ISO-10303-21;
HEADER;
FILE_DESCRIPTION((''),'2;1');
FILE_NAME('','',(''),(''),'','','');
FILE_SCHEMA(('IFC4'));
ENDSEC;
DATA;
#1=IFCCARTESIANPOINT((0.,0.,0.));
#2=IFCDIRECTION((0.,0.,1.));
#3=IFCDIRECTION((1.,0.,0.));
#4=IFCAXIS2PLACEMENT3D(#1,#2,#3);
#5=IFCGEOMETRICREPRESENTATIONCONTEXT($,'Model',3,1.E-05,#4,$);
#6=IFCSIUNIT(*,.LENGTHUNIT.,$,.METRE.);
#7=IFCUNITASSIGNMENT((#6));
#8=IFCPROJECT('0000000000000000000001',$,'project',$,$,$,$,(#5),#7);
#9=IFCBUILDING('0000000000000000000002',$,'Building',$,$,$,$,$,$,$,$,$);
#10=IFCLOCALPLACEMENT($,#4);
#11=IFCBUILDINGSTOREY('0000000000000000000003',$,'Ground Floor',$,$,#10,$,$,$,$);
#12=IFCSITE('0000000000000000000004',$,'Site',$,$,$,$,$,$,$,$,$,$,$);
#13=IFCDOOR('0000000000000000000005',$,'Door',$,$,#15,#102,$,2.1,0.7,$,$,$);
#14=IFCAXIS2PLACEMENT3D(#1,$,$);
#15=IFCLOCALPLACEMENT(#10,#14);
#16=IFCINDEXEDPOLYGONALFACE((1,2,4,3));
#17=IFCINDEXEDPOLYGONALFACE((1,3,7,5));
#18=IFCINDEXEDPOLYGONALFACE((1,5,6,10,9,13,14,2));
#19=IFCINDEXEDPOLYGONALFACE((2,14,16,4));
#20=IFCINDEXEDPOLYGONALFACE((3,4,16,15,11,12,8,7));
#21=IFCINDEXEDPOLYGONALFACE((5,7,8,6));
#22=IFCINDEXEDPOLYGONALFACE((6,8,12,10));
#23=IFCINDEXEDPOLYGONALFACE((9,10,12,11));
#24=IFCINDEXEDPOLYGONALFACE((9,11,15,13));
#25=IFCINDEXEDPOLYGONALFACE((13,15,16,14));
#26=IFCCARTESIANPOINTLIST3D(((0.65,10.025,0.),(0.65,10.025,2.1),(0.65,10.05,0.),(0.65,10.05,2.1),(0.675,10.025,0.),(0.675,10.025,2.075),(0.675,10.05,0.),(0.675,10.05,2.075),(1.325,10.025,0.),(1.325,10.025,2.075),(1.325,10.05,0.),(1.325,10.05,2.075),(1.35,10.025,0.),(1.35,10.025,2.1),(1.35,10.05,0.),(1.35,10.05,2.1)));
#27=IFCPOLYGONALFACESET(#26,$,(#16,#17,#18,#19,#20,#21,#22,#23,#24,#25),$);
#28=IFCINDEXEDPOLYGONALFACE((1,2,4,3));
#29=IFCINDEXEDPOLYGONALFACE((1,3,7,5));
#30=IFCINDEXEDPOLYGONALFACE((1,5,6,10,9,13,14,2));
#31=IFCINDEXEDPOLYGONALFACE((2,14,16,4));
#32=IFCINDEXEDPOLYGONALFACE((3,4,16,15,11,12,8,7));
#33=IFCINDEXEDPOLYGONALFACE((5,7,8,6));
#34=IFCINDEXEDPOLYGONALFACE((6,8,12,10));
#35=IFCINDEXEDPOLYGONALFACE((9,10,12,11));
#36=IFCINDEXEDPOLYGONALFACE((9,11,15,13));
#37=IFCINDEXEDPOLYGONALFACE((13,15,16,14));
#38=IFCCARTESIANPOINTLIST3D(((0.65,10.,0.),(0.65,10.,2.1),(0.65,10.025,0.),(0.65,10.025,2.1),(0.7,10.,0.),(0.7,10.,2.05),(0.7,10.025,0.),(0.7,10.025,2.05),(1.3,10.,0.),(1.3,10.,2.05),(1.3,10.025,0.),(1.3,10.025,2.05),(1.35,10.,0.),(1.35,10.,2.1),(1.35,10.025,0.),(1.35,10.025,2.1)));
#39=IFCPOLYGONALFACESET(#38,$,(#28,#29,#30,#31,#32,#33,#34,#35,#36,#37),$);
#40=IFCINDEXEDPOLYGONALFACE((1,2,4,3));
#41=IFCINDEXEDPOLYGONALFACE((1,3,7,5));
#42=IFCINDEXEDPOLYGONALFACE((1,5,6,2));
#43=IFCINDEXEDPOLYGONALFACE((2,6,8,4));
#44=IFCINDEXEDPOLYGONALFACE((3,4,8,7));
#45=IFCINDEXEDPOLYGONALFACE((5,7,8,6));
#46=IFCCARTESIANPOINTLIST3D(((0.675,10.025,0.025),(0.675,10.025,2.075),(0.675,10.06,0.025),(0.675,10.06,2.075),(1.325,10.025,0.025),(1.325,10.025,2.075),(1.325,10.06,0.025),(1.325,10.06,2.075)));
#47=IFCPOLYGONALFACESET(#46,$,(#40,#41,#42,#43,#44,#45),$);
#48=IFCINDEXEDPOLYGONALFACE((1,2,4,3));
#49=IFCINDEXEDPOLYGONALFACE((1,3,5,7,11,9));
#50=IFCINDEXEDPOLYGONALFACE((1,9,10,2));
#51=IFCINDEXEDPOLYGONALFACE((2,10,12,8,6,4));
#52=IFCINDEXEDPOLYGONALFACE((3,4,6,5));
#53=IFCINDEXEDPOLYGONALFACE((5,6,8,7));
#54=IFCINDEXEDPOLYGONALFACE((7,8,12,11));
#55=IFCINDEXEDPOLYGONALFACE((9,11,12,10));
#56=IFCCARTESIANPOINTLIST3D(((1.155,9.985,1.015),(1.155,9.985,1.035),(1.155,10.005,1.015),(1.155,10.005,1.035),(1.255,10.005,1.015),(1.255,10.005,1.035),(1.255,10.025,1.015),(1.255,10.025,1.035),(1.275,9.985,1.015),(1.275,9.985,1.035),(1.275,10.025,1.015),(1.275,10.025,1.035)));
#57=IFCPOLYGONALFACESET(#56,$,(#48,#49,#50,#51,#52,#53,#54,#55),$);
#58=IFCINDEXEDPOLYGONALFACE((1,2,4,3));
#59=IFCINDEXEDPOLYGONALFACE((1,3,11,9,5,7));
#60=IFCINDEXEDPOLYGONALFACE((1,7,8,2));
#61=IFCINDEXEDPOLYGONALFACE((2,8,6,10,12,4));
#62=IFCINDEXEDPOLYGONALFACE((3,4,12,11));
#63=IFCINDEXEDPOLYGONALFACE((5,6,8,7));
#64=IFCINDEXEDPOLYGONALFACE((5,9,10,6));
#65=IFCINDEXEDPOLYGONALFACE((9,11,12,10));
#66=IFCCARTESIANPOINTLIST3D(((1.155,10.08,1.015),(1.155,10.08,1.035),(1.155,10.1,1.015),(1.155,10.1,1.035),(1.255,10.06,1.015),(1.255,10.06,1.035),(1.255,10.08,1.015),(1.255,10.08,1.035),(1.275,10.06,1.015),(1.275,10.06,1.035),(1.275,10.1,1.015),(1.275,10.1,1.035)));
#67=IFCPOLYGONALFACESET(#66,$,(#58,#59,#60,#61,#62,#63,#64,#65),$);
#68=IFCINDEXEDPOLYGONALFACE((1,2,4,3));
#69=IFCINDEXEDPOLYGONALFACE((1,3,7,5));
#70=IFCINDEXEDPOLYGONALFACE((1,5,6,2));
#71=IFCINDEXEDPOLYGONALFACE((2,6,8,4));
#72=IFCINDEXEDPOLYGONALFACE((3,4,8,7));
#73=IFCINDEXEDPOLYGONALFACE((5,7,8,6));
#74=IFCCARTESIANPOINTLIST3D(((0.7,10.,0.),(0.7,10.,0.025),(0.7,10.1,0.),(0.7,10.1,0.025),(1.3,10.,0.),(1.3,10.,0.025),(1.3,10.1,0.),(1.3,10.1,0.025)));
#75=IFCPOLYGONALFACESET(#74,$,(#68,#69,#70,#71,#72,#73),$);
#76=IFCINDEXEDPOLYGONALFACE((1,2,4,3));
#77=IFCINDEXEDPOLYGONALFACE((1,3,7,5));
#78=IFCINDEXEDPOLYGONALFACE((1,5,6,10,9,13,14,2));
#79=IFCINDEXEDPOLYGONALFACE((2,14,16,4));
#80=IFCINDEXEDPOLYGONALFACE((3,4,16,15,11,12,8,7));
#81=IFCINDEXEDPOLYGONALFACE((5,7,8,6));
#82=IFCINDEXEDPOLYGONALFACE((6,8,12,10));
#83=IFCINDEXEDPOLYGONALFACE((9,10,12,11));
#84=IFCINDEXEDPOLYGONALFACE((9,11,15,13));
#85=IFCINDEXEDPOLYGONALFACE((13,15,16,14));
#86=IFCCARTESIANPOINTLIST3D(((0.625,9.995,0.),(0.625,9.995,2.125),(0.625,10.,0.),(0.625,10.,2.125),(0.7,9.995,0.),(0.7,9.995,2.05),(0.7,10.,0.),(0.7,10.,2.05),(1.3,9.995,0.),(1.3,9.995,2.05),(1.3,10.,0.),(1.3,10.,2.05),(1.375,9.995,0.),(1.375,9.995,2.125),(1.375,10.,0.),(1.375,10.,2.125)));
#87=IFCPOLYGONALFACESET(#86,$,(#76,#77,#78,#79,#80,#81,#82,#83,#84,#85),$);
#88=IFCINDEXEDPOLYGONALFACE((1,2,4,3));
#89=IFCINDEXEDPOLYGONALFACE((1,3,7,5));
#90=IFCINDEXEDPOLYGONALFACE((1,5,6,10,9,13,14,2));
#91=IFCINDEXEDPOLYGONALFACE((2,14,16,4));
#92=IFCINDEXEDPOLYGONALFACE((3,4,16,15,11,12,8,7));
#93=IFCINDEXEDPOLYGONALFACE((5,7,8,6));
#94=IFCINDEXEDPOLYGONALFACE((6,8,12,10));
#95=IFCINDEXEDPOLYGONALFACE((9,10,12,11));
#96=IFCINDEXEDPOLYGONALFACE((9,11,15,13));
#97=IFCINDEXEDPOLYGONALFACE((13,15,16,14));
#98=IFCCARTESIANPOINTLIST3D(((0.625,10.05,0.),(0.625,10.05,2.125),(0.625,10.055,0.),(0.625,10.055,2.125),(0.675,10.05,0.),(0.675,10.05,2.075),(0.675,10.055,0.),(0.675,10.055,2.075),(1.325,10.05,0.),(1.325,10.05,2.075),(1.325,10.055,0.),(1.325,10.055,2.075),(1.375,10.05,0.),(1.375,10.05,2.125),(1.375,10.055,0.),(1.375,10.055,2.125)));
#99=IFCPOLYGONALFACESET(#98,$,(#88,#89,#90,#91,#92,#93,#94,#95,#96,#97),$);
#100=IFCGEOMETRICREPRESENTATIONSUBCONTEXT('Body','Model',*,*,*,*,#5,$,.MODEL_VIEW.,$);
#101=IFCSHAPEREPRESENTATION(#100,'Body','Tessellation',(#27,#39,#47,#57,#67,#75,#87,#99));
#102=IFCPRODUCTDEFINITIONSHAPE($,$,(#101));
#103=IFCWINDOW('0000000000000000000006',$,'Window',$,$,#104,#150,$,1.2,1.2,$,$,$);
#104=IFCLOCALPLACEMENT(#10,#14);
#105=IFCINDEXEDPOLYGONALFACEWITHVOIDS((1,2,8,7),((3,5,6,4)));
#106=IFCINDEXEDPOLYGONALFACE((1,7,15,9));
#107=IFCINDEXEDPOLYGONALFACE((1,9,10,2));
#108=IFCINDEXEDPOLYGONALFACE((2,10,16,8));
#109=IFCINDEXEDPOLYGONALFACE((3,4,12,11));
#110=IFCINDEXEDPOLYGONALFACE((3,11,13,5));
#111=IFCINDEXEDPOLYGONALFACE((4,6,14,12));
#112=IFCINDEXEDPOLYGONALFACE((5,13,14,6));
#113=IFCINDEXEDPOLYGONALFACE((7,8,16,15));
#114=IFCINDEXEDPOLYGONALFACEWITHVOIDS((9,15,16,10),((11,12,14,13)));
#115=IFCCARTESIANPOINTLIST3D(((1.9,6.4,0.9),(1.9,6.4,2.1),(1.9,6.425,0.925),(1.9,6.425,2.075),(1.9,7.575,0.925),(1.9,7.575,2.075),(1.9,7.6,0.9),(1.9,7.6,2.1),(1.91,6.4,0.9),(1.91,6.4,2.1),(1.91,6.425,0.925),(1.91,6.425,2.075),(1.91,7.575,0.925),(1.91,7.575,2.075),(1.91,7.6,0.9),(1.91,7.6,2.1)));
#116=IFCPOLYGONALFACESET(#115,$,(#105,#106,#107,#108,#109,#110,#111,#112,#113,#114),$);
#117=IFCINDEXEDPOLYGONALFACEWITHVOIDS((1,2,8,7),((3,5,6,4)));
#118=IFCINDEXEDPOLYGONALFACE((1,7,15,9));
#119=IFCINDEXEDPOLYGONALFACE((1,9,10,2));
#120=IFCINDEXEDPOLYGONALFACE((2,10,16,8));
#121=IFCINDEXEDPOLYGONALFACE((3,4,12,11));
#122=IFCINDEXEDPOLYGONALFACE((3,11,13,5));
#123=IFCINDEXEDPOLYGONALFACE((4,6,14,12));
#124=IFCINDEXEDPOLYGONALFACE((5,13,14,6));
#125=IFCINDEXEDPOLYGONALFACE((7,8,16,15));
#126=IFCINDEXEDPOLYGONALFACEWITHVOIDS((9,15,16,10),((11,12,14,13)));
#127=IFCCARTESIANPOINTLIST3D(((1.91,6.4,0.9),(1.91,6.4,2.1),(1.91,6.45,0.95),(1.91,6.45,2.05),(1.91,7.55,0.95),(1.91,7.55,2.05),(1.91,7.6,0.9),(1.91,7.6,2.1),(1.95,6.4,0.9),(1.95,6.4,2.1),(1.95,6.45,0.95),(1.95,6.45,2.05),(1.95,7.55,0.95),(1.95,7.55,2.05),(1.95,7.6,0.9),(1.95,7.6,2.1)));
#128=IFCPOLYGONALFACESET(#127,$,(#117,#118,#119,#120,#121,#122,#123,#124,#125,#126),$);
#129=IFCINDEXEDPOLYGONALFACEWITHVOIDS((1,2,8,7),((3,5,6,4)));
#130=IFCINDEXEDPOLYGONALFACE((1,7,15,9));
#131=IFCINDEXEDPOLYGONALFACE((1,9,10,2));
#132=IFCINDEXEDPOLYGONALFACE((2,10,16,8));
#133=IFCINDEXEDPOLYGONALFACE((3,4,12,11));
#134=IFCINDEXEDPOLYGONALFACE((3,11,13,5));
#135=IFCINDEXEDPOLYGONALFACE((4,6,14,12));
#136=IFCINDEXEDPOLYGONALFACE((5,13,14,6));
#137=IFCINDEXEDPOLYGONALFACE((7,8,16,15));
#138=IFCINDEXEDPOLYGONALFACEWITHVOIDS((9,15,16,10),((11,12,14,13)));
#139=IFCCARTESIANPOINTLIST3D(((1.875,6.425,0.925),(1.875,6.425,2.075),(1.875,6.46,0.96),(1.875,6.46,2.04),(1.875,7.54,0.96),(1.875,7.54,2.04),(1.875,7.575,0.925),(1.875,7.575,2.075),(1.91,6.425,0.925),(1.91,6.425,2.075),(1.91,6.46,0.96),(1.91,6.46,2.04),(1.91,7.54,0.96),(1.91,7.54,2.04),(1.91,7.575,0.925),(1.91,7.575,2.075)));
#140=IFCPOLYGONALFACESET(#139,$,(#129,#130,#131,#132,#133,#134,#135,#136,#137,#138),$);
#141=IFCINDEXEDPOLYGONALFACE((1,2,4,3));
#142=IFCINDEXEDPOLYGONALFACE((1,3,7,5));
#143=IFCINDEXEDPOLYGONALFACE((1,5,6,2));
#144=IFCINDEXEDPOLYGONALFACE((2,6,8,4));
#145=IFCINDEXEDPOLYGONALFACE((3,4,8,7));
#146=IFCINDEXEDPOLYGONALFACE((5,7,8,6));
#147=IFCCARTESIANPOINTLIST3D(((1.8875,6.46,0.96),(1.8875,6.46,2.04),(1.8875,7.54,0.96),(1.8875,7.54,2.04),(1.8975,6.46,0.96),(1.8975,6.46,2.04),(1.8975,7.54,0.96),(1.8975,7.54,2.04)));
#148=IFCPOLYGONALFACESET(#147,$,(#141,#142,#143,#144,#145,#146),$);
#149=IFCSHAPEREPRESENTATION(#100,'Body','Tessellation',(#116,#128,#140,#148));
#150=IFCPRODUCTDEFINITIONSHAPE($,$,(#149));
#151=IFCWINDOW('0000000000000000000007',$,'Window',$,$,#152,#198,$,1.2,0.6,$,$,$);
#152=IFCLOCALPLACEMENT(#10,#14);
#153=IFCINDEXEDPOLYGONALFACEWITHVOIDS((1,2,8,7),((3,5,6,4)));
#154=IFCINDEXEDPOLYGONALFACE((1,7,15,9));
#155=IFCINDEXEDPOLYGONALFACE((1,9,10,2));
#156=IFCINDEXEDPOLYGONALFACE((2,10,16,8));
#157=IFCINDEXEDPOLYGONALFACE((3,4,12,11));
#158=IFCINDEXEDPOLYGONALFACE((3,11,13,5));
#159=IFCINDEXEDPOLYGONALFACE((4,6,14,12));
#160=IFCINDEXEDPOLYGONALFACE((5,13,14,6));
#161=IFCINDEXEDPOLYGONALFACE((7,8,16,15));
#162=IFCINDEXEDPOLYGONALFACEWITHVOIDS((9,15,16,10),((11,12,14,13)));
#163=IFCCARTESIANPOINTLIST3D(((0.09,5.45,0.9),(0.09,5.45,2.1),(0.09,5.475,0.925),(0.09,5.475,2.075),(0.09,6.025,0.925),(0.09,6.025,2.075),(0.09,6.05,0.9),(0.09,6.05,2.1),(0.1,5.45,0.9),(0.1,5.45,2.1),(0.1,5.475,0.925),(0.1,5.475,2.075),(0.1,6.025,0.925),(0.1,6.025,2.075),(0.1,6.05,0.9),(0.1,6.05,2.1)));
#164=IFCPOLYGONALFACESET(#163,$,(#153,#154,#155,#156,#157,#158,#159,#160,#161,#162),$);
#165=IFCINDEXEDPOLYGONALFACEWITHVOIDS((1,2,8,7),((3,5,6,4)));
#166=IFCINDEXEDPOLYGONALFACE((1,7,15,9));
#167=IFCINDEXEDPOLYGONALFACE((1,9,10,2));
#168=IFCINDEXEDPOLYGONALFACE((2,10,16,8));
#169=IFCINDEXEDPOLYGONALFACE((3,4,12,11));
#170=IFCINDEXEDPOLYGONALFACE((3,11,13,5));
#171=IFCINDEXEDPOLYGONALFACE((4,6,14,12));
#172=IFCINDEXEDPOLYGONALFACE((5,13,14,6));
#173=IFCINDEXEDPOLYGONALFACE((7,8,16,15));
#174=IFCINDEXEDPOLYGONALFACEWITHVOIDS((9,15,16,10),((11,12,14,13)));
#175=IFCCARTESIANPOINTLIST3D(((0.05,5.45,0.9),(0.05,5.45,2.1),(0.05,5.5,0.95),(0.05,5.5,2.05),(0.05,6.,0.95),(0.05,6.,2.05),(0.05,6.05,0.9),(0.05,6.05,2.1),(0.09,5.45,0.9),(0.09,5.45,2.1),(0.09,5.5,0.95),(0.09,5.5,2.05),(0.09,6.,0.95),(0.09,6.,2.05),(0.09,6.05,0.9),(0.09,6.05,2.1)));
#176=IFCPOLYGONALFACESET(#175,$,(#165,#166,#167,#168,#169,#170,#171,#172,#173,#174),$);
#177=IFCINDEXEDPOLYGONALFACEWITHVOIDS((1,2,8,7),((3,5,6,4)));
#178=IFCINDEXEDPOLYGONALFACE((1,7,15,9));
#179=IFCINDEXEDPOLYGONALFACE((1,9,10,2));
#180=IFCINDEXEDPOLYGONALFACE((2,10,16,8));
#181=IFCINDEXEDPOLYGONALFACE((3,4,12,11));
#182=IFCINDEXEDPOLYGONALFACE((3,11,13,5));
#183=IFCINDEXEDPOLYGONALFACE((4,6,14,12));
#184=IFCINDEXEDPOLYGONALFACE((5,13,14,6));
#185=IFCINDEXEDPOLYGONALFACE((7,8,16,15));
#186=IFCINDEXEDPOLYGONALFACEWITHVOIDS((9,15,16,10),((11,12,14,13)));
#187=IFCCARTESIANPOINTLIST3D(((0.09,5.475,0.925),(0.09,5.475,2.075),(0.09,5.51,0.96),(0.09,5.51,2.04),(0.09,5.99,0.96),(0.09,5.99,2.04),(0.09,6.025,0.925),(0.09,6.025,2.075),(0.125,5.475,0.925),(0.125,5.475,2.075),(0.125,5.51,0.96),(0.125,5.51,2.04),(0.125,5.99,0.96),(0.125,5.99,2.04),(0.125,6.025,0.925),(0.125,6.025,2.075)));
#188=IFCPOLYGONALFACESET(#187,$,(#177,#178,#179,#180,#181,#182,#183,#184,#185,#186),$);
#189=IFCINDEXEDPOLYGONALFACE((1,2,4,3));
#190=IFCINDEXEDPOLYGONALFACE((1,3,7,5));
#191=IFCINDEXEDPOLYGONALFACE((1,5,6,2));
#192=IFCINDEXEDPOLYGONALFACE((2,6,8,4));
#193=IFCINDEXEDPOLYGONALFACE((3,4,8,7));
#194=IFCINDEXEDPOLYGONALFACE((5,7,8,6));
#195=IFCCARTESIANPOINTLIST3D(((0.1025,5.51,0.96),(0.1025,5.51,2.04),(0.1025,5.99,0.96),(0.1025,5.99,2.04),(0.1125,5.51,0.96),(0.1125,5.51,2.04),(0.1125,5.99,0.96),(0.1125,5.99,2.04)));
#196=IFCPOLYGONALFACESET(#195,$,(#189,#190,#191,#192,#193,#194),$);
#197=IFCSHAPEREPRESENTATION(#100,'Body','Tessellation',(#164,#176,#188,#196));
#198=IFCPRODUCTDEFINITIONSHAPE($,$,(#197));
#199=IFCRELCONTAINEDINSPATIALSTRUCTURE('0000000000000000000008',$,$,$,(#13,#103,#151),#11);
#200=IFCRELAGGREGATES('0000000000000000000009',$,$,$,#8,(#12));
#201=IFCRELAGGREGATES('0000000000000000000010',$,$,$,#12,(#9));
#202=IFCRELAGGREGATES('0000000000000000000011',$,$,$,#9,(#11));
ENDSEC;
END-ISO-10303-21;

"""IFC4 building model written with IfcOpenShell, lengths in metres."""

from ifc_helpers import new_model, si_unit, frame, origin_with_axes, place, context, subcontext, project, spatial, line, indexed_curve, outline, extrude, element, save


model = new_model("IFC4")

# Units and contexts
model_context = context("Model", 3, precision=1e-05, world=origin_with_axes())
body_context = subcontext(model_context, "Body", "Model", "MODEL_VIEW")
ifc_project = project(units=[si_unit("LENGTHUNIT", "METRE")], contexts=[model_context])

# Site, building, storey
site = spatial("IfcSite", under=ifc_project, Name="Site")
building = spatial("IfcBuilding", under=site, Name="Building")
storey_placement = place(None, origin_with_axes())
storey = spatial("IfcBuildingStorey", under=building, at=storey_placement, Name="Ground Floor")

# Door
door_1_placement = place(storey_placement, frame((0.65, 10.0, 0.0), z_axis=(0.0, 0.0, 1.0), x_axis=(1.0, 0.0, 0.0)))
element("IfcDoor", 1, at=door_1_placement, inside=storey, Name="Door", OverallHeight=2.1, OverallWidth=0.7, context=body_context, shape_type="SweptSolid", body=[
    extrude(outline(indexed_curve([(0.0, 0.0), (0.0, 2.1), (0.7, 2.1), (0.7, 0.0), (0.675, 0.0), (0.675, 2.075), (0.025, 2.075), (0.025, 0.0)], segments=[line(1, 2, 3, 4, 5, 6, 7, 8, 1)])), frame((0.0, 0.025, 0.0), z_axis=(0.0, -1.0, 0.0), x_axis=(1.0, 0.0, 0.0)), (0.0, 0.0, -1.0), 0.025),
    extrude(outline(indexed_curve([(0.0, 0.0), (0.0, 2.1), (0.7, 2.1), (0.7, 0.0), (0.65, 0.0), (0.65, 2.05), (0.05, 2.05), (0.05, 0.0)], segments=[line(1, 2, 3, 4, 5, 6, 7, 8, 1)])), frame((0.0, 0.0, 0.0), z_axis=(0.0, -1.0, 0.0), x_axis=(1.0, 0.0, 0.0)), (0.0, 0.0, -1.0), 0.025),
    extrude(outline(indexed_curve([(0.0, 0.0), (0.65, 0.0), (0.65, 0.035), (0.0, 0.035)], segments=[line(1, 2, 3, 4, 1)])), frame((0.025, 0.025, 0.025), z_axis=(0.0, 0.0, 1.0), x_axis=(1.0, 0.0, 0.0)), (0.0, 0.0, 1.0), 2.05),
    extrude(outline(indexed_curve([(0.0, 0.0), (0.0, -0.04), (-0.12, -0.04), (-0.12, -0.02), (-0.02, -0.02), (-0.02, 0.0)], segments=[line(1, 2, 3, 4, 5, 6, 1)])), frame((0.625, 0.025, 1.015), z_axis=(0.0, 0.0, 1.0), x_axis=(1.0, 0.0, 0.0)), (0.0, 0.0, 1.0), 0.02),
    extrude(outline(indexed_curve([(0.0, 0.0), (0.0, 0.04), (-0.12, 0.04), (-0.12, 0.02), (-0.02, 0.02), (-0.02, 0.0)], segments=[line(1, 2, 3, 4, 5, 6, 1)])), frame((0.625, 0.06, 1.015), z_axis=(0.0, 0.0, 1.0), x_axis=(1.0, 0.0, 0.0)), (0.0, 0.0, 1.0), 0.02),
    extrude(outline(indexed_curve([(0.0, 0.0), (0.6, 0.0), (0.6, 0.1), (0.0, 0.1)], segments=[line(1, 2, 3, 4, 1)])), frame((0.05, 0.0, 0.0), z_axis=(0.0, 0.0, 1.0), x_axis=(1.0, 0.0, 0.0)), (0.0, 0.0, 1.0), 0.025),
    extrude(outline(indexed_curve([(0.0, 0.0), (0.0, 2.125), (0.75, 2.125), (0.75, 0.0), (0.675, 0.0), (0.675, 2.05), (0.075, 2.05), (0.075, 0.0)], segments=[line(1, 2, 3, 4, 5, 6, 7, 8, 1)])), frame((-0.025, -0.005, 0.0), z_axis=(0.0, -1.0, 0.0), x_axis=(1.0, 0.0, 0.0)), (0.0, 0.0, -1.0), 0.005),
    extrude(outline(indexed_curve([(0.0, 0.0), (0.0, 2.125), (0.75, 2.125), (0.75, 0.0), (0.7, 0.0), (0.7, 2.075), (0.05, 2.075), (0.05, 0.0)], segments=[line(1, 2, 3, 4, 5, 6, 7, 8, 1)])), frame((-0.025, 0.05, 0.0), z_axis=(0.0, -1.0, 0.0), x_axis=(1.0, 0.0, 0.0)), (0.0, 0.0, -1.0), 0.005),
])

# Windows
window_1_placement = place(storey_placement, frame((2.0, 6.4, 0.9), z_axis=(0.0, 0.0, 1.0), x_axis=(0.0, 1.0, 0.0)))
element("IfcWindow", 2, at=window_1_placement, inside=storey, Name="Window", OverallHeight=1.2, OverallWidth=1.2, context=body_context, shape_type="SweptSolid", body=[
    extrude(outline(indexed_curve([(0.0, 0.0), (1.2, 0.0), (1.2, 1.2), (0.0, 1.2)], segments=[line(1, 2, 3, 4, 1)]), holes=[indexed_curve([(0.025, 0.025), (1.175, 0.025), (1.175, 1.175), (0.025, 1.175)], segments=[line(1, 2, 3, 4, 1)])]), frame((0.0, 0.09, 0.0), z_axis=(0.0, -1.0, 0.0), x_axis=(1.0, 0.0, 0.0)), (0.0, 0.0, -1.0), 0.01),
    extrude(outline(indexed_curve([(0.0, 0.0), (1.2, 0.0), (1.2, 1.2), (0.0, 1.2)], segments=[line(1, 2, 3, 4, 1)]), holes=[indexed_curve([(0.05, 0.05), (1.15, 0.05), (1.15, 1.15), (0.05, 1.15)], segments=[line(1, 2, 3, 4, 1)])]), frame((0.0, 0.05, 0.0), z_axis=(0.0, -1.0, 0.0), x_axis=(1.0, 0.0, 0.0)), (0.0, 0.0, -1.0), 0.04),
    extrude(outline(indexed_curve([(0.0, 0.0), (1.15, 0.0), (1.15, 1.15), (0.0, 1.15)], segments=[line(1, 2, 3, 4, 1)]), holes=[indexed_curve([(0.035, 0.035), (1.115, 0.035), (1.115, 1.115), (0.035, 1.115)], segments=[line(1, 2, 3, 4, 1)])]), frame((0.025, 0.09, 0.025), z_axis=(0.0, -1.0, 0.0), x_axis=(1.0, 0.0, 0.0)), (0.0, 0.0, -1.0), 0.035),
    extrude(outline(indexed_curve([(0.035, 0.035), (1.115, 0.035), (1.115, 1.115), (0.035, 1.115)], segments=[line(1, 2, 3, 4, 1)])), frame((0.025, 0.1025, 0.025), z_axis=(0.0, -1.0, 0.0), x_axis=(1.0, 0.0, 0.0)), (0.0, 0.0, -1.0), 0.01),
])
window_2_placement = place(storey_placement, frame((0.0, 6.05, 0.9), z_axis=(0.0, 0.0, 1.0), x_axis=(0.0, -1.0, 0.0)))
element("IfcWindow", 3, at=window_2_placement, inside=storey, Name="Window", OverallHeight=1.2, OverallWidth=0.6, context=body_context, shape_type="SweptSolid", body=[
    extrude(outline(indexed_curve([(0.0, 0.0), (0.6, 0.0), (0.6, 1.2), (0.0, 1.2)], segments=[line(1, 2, 3, 4, 1)]), holes=[indexed_curve([(0.025, 0.025), (0.575, 0.025), (0.575, 1.175), (0.025, 1.175)], segments=[line(1, 2, 3, 4, 1)])]), frame((0.0, 0.09, 0.0), z_axis=(0.0, -1.0, 0.0), x_axis=(1.0, 0.0, 0.0)), (0.0, 0.0, -1.0), 0.01),
    extrude(outline(indexed_curve([(0.0, 0.0), (0.6, 0.0), (0.6, 1.2), (0.0, 1.2)], segments=[line(1, 2, 3, 4, 1)]), holes=[indexed_curve([(0.05, 0.05), (0.55, 0.05), (0.55, 1.15), (0.05, 1.15)], segments=[line(1, 2, 3, 4, 1)])]), frame((0.0, 0.05, 0.0), z_axis=(0.0, -1.0, 0.0), x_axis=(1.0, 0.0, 0.0)), (0.0, 0.0, -1.0), 0.04),
    extrude(outline(indexed_curve([(0.0, 0.0), (0.55, 0.0), (0.55, 1.15), (0.0, 1.15)], segments=[line(1, 2, 3, 4, 1)]), holes=[indexed_curve([(0.035, 0.035), (0.515, 0.035), (0.515, 1.115), (0.035, 1.115)], segments=[line(1, 2, 3, 4, 1)])]), frame((0.025, 0.09, 0.025), z_axis=(0.0, -1.0, 0.0), x_axis=(1.0, 0.0, 0.0)), (0.0, 0.0, -1.0), 0.035),
    extrude(outline(indexed_curve([(0.035, 0.035), (0.515, 0.035), (0.515, 1.115), (0.035, 1.115)], segments=[line(1, 2, 3, 4, 1)])), frame((0.025, 0.1025, 0.025), z_axis=(0.0, -1.0, 0.0), x_axis=(1.0, 0.0, 0.0)), (0.0, 0.0, -1.0), 0.01),
])

save(model, "model.ifc")
